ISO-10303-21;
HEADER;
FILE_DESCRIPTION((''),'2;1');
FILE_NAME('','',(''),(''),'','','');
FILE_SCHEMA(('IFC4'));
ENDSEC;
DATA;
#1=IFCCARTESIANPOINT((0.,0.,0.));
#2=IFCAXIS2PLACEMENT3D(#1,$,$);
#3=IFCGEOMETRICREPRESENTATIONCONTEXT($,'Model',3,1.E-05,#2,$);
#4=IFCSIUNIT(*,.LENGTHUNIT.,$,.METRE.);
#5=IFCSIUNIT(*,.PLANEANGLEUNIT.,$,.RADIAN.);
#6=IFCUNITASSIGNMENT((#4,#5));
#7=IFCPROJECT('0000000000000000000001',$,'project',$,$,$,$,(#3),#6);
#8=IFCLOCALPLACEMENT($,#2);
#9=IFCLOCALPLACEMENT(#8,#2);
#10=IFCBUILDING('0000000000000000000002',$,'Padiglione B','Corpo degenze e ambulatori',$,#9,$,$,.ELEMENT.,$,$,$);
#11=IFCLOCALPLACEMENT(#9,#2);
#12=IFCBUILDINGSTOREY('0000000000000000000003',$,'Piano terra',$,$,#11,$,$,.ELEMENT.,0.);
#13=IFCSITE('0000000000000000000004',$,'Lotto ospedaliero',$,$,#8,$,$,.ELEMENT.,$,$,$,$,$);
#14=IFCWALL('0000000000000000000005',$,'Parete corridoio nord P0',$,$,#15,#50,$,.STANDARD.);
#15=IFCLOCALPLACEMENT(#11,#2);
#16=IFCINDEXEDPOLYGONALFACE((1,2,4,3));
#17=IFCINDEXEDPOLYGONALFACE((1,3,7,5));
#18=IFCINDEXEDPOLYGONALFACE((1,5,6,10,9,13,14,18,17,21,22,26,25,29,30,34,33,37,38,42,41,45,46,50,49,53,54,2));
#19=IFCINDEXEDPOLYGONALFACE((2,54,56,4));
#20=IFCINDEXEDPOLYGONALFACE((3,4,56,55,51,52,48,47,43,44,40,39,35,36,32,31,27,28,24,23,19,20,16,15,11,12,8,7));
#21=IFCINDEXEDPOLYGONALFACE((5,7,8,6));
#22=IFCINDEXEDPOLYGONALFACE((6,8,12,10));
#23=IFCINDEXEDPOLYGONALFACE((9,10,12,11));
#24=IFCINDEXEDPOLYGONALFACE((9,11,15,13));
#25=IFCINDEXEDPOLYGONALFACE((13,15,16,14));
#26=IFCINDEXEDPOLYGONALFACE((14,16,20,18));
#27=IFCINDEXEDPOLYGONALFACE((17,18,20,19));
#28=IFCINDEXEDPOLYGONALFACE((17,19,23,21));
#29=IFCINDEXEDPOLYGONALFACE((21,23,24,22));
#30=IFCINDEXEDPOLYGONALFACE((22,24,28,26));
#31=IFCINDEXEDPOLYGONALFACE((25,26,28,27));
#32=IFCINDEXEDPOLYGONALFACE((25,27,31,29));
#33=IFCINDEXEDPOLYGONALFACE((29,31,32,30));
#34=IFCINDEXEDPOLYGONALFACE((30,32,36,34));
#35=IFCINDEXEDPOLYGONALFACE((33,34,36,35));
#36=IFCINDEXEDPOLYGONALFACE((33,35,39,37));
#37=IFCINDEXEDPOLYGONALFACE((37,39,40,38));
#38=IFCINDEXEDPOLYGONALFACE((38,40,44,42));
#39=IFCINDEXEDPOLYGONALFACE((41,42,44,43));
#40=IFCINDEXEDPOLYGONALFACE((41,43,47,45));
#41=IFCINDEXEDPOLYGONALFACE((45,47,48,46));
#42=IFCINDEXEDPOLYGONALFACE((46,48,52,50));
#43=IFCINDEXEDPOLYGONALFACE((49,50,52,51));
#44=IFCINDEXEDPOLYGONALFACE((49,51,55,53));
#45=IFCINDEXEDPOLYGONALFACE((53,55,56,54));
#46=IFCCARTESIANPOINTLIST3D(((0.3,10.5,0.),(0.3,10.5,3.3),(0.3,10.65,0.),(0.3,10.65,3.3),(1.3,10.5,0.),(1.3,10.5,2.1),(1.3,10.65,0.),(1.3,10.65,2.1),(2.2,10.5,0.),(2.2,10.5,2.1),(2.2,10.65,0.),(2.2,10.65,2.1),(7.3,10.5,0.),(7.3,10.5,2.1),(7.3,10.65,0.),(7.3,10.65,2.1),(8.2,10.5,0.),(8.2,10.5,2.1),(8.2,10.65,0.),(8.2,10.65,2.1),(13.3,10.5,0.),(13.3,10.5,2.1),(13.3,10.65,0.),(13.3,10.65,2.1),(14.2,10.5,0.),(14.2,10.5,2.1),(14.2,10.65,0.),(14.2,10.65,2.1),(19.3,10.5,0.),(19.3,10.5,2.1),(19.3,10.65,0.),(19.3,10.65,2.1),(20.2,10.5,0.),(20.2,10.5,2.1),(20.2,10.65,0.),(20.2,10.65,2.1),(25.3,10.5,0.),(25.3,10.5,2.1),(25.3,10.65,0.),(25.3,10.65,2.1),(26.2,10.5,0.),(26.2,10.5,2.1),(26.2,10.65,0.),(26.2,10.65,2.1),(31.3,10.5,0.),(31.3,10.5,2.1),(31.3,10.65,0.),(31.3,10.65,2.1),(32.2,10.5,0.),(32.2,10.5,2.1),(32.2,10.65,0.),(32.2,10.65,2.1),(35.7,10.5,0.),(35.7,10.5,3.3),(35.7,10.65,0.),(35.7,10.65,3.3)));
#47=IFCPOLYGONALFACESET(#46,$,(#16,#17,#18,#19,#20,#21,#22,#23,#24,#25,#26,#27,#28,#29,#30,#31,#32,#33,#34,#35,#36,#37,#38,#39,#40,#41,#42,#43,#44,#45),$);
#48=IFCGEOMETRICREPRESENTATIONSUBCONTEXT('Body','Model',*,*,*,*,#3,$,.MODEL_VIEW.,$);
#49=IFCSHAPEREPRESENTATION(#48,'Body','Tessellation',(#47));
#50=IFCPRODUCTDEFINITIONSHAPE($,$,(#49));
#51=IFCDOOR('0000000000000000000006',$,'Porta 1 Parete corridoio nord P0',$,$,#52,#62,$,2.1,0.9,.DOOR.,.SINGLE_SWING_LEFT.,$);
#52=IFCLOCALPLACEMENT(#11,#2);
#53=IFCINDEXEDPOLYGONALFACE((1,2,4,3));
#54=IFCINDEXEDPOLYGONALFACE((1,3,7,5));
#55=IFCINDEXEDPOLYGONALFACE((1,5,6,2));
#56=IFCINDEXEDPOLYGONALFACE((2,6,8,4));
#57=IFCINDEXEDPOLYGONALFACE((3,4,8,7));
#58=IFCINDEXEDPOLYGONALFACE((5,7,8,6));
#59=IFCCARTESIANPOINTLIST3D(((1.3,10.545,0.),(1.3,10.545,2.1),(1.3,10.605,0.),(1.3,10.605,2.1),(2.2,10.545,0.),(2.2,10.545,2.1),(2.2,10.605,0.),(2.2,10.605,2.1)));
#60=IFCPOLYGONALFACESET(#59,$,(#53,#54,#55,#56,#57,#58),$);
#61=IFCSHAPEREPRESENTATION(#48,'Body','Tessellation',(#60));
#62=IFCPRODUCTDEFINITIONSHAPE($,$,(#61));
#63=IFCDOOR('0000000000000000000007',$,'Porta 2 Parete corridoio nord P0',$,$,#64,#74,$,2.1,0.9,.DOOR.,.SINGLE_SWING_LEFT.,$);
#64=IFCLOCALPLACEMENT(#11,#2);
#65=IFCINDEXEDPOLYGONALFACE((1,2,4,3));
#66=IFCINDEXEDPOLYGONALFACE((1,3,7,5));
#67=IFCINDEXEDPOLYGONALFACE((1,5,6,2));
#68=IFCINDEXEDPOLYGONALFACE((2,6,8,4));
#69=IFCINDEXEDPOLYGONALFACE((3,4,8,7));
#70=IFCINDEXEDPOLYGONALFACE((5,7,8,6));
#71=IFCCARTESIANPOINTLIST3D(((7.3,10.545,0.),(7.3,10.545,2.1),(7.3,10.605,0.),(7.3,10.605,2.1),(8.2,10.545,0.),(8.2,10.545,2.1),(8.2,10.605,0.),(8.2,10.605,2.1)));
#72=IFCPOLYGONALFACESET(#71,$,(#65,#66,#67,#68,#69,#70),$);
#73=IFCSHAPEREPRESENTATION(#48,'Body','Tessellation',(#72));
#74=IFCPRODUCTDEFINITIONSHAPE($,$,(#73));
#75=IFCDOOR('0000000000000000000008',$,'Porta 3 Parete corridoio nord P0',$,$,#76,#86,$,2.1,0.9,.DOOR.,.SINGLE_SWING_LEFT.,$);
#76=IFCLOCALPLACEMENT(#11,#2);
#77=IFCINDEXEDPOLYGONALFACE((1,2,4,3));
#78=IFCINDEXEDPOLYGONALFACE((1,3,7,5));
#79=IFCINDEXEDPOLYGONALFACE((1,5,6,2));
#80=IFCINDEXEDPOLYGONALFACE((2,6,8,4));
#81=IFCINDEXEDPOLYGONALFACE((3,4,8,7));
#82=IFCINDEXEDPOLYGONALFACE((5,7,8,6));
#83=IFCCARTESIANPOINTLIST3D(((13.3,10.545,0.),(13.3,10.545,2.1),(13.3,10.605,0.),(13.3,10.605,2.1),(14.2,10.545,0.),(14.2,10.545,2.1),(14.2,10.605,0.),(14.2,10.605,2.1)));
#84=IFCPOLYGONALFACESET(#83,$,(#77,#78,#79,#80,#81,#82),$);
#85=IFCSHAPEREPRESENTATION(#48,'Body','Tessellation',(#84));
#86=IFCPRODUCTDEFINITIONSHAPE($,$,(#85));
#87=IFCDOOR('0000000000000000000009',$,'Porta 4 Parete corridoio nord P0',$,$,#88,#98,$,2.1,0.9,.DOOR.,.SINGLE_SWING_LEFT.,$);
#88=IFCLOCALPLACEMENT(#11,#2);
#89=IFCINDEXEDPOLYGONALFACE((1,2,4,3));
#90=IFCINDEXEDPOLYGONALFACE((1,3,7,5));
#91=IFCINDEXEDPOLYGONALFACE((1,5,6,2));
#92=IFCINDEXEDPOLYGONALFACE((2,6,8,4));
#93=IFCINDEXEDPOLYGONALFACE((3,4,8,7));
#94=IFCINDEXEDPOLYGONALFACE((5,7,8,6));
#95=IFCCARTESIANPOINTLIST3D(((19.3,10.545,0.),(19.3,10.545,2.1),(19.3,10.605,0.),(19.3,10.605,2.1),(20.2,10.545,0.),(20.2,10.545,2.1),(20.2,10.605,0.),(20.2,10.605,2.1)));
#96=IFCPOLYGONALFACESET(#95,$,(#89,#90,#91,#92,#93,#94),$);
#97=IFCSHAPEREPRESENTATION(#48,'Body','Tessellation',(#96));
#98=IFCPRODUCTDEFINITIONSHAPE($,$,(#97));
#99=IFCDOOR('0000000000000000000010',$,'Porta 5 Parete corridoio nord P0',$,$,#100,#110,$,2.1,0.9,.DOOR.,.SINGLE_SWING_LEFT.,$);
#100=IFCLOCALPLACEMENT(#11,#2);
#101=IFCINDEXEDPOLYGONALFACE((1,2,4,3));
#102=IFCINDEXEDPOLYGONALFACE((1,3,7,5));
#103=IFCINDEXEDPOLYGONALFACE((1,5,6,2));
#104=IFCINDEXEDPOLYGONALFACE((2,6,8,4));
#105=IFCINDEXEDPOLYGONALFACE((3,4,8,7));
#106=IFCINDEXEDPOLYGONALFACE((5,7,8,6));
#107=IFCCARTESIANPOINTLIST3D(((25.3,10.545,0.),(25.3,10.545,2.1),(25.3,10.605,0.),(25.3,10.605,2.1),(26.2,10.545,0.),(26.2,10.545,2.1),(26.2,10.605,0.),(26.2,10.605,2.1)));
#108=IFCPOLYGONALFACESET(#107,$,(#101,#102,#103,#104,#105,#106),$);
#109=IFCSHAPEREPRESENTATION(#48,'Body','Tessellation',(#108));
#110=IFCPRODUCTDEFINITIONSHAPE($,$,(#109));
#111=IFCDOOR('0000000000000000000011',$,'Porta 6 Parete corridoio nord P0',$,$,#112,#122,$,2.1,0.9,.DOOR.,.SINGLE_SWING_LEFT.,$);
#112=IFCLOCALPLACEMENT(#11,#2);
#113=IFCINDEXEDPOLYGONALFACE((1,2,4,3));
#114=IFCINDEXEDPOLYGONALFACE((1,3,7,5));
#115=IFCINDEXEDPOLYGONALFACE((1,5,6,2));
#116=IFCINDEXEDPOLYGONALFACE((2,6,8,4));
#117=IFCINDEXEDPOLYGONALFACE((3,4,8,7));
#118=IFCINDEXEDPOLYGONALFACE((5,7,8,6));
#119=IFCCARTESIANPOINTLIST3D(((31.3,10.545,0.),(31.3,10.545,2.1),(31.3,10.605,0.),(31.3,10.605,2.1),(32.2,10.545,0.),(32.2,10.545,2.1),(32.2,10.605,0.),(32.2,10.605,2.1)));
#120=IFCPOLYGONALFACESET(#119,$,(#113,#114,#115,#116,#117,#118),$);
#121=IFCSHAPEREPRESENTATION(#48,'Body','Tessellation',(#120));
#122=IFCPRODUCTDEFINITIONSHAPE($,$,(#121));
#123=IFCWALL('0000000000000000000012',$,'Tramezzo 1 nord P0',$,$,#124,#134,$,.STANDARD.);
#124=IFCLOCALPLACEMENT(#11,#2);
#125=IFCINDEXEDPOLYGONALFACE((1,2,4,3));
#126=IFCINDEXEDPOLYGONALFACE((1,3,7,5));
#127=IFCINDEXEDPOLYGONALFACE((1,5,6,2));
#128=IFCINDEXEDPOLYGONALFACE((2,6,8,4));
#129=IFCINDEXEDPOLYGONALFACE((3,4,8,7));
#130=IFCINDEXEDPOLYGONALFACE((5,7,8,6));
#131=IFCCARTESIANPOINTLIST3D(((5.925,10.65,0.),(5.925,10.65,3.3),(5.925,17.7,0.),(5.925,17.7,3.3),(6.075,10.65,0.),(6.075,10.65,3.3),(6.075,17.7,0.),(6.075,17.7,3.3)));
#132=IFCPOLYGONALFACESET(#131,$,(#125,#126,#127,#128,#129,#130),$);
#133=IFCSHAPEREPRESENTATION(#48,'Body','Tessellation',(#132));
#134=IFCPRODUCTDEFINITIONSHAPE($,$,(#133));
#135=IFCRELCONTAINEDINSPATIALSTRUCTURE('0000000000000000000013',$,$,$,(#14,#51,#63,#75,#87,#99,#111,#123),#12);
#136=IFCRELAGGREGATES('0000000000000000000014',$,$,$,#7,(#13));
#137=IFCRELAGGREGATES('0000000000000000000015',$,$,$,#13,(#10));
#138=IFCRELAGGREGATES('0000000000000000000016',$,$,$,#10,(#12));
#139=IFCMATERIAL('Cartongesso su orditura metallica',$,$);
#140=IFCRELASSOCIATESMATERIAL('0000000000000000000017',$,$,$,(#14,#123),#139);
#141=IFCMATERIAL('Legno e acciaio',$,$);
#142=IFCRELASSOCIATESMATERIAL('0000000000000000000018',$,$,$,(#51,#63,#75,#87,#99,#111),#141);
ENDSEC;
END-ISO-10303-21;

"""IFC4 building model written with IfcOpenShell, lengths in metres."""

from ifc_helpers import new_model, si_unit, frame, frame_2d, origin, place, context, subcontext, project, spatial, rectangle, extrude, material, element, fill, save


model = new_model("IFC4")

# Units and contexts
model_context = context("Model", 3, precision=1e-05, world=origin())
body_context = subcontext(model_context, "Body", "Model", "MODEL_VIEW")
ifc_project = project(units=[si_unit("LENGTHUNIT", "METRE"), si_unit("PLANEANGLEUNIT", "RADIAN")], contexts=[model_context])

# Site, building, storey
site_placement = place(None, origin())
site = spatial("IfcSite", under=ifc_project, at=site_placement, Name="Lotto ospedaliero", CompositionType="ELEMENT")
building_placement = place(site_placement, origin())
building = spatial("IfcBuilding", under=site, at=building_placement, Name="Padiglione B", Description="Corpo degenze e ambulatori", CompositionType="ELEMENT")
storey_placement = place(building_placement, origin())
storey = spatial("IfcBuildingStorey", under=building, at=storey_placement, Name="Piano terra", CompositionType="ELEMENT", Elevation=0.0)

# Wall, openings, doors
ifc_material_1 = material(Name="Cartongesso su orditura metallica")
ifc_material_2 = material(Name="Legno e acciaio")
wall_1_placement = place(storey_placement, frame((0.3, 10.5, 0.0)))
wall_1 = element("IfcWall", 1, at=wall_1_placement, inside=storey, material=ifc_material_1, Name="Parete corridoio nord P0", PredefinedType="STANDARD", context=body_context, shape_type="SweptSolid", body=[
    extrude(rectangle(XDim=35.4, YDim=0.15, at=frame_2d((17.7, 0.075))), origin(), (0.0, 0.0, 1.0), 3.3),
])
opening_1_placement = place(wall_1_placement, frame((1.0, -0.1, 0.0)))
opening_1 = element("IfcOpeningElement", 2, at=opening_1_placement, cuts=wall_1, PredefinedType="OPENING", context=body_context, shape_type="SweptSolid", body=[
    extrude(rectangle(XDim=0.9, YDim=0.35, at=frame_2d((0.45, 0.175))), origin(), (0.0, 0.0, 1.0), 2.1),
])
opening_2_placement = place(wall_1_placement, frame((7.0, -0.1, 0.0)))
opening_2 = element("IfcOpeningElement", 3, at=opening_2_placement, cuts=wall_1, PredefinedType="OPENING", context=body_context, shape_type="SweptSolid", body=[
    extrude(rectangle(XDim=0.9, YDim=0.35, at=frame_2d((0.45, 0.175))), origin(), (0.0, 0.0, 1.0), 2.1),
])
opening_3_placement = place(wall_1_placement, frame((13.0, -0.1, 0.0)))
opening_3 = element("IfcOpeningElement", 4, at=opening_3_placement, cuts=wall_1, PredefinedType="OPENING", context=body_context, shape_type="SweptSolid", body=[
    extrude(rectangle(XDim=0.9, YDim=0.35, at=frame_2d((0.45, 0.175))), origin(), (0.0, 0.0, 1.0), 2.1),
])
opening_4_placement = place(wall_1_placement, frame((19.0, -0.1, 0.0)))
opening_4 = element("IfcOpeningElement", 5, at=opening_4_placement, cuts=wall_1, PredefinedType="OPENING", context=body_context, shape_type="SweptSolid", body=[
    extrude(rectangle(XDim=0.9, YDim=0.35, at=frame_2d((0.45, 0.175))), origin(), (0.0, 0.0, 1.0), 2.1),
])
opening_5_placement = place(wall_1_placement, frame((25.0, -0.1, 0.0)))
opening_5 = element("IfcOpeningElement", 6, at=opening_5_placement, cuts=wall_1, PredefinedType="OPENING", context=body_context, shape_type="SweptSolid", body=[
    extrude(rectangle(XDim=0.9, YDim=0.35, at=frame_2d((0.45, 0.175))), origin(), (0.0, 0.0, 1.0), 2.1),
])
opening_6_placement = place(wall_1_placement, frame((31.0, -0.1, 0.0)))
opening_6 = element("IfcOpeningElement", 7, at=opening_6_placement, cuts=wall_1, PredefinedType="OPENING", context=body_context, shape_type="SweptSolid", body=[
    extrude(rectangle(XDim=0.9, YDim=0.35, at=frame_2d((0.45, 0.175))), origin(), (0.0, 0.0, 1.0), 2.1),
])
door_1_placement = place(wall_1_placement, frame((1.0, 0.045, 0.0)))
door_1 = element("IfcDoor", 8, at=door_1_placement, inside=storey, material=ifc_material_2, Name="Porta 1 Parete corridoio nord P0", OperationType="SINGLE_SWING_LEFT", OverallHeight=2.1, OverallWidth=0.9, PredefinedType="DOOR", context=body_context, shape_type="SweptSolid", body=[
    extrude(rectangle(XDim=0.9, YDim=0.06, at=frame_2d((0.45, 0.03))), origin(), (0.0, 0.0, 1.0), 2.1),
])
fill(opening_1, door_1)
door_2_placement = place(wall_1_placement, frame((7.0, 0.045, 0.0)))
door_2 = element("IfcDoor", 9, at=door_2_placement, inside=storey, material=ifc_material_2, Name="Porta 2 Parete corridoio nord P0", OperationType="SINGLE_SWING_LEFT", OverallHeight=2.1, OverallWidth=0.9, PredefinedType="DOOR", context=body_context, shape_type="SweptSolid", body=[
    extrude(rectangle(XDim=0.9, YDim=0.06, at=frame_2d((0.45, 0.03))), origin(), (0.0, 0.0, 1.0), 2.1),
])
fill(opening_2, door_2)
door_3_placement = place(wall_1_placement, frame((13.0, 0.045, 0.0)))
door_3 = element("IfcDoor", 10, at=door_3_placement, inside=storey, material=ifc_material_2, Name="Porta 3 Parete corridoio nord P0", OperationType="SINGLE_SWING_LEFT", OverallHeight=2.1, OverallWidth=0.9, PredefinedType="DOOR", context=body_context, shape_type="SweptSolid", body=[
    extrude(rectangle(XDim=0.9, YDim=0.06, at=frame_2d((0.45, 0.03))), origin(), (0.0, 0.0, 1.0), 2.1),
])
fill(opening_3, door_3)
door_4_placement = place(wall_1_placement, frame((19.0, 0.045, 0.0)))
door_4 = element("IfcDoor", 11, at=door_4_placement, inside=storey, material=ifc_material_2, Name="Porta 4 Parete corridoio nord P0", OperationType="SINGLE_SWING_LEFT", OverallHeight=2.1, OverallWidth=0.9, PredefinedType="DOOR", context=body_context, shape_type="SweptSolid", body=[
    extrude(rectangle(XDim=0.9, YDim=0.06, at=frame_2d((0.45, 0.03))), origin(), (0.0, 0.0, 1.0), 2.1),
])
fill(opening_4, door_4)
door_5_placement = place(wall_1_placement, frame((25.0, 0.045, 0.0)))
door_5 = element("IfcDoor", 12, at=door_5_placement, inside=storey, material=ifc_material_2, Name="Porta 5 Parete corridoio nord P0", OperationType="SINGLE_SWING_LEFT", OverallHeight=2.1, OverallWidth=0.9, PredefinedType="DOOR", context=body_context, shape_type="SweptSolid", body=[
    extrude(rectangle(XDim=0.9, YDim=0.06, at=frame_2d((0.45, 0.03))), origin(), (0.0, 0.0, 1.0), 2.1),
])
fill(opening_5, door_5)
door_6_placement = place(wall_1_placement, frame((31.0, 0.045, 0.0)))
door_6 = element("IfcDoor", 13, at=door_6_placement, inside=storey, material=ifc_material_2, Name="Porta 6 Parete corridoio nord P0", OperationType="SINGLE_SWING_LEFT", OverallHeight=2.1, OverallWidth=0.9, PredefinedType="DOOR", context=body_context, shape_type="SweptSolid", body=[
    extrude(rectangle(XDim=0.9, YDim=0.06, at=frame_2d((0.45, 0.03))), origin(), (0.0, 0.0, 1.0), 2.1),
])
fill(opening_6, door_6)

# Wall
wall_2_placement = place(storey_placement, frame((5.925, 10.65, 0.0)))
element("IfcWall", 14, at=wall_2_placement, inside=storey, material=ifc_material_1, Name="Tramezzo 1 nord P0", PredefinedType="STANDARD", context=body_context, shape_type="SweptSolid", body=[
    extrude(rectangle(XDim=0.15, YDim=7.05, at=frame_2d((0.075, 3.525))), origin(), (0.0, 0.0, 1.0), 3.3),
])

save(model, "model.ifc")
